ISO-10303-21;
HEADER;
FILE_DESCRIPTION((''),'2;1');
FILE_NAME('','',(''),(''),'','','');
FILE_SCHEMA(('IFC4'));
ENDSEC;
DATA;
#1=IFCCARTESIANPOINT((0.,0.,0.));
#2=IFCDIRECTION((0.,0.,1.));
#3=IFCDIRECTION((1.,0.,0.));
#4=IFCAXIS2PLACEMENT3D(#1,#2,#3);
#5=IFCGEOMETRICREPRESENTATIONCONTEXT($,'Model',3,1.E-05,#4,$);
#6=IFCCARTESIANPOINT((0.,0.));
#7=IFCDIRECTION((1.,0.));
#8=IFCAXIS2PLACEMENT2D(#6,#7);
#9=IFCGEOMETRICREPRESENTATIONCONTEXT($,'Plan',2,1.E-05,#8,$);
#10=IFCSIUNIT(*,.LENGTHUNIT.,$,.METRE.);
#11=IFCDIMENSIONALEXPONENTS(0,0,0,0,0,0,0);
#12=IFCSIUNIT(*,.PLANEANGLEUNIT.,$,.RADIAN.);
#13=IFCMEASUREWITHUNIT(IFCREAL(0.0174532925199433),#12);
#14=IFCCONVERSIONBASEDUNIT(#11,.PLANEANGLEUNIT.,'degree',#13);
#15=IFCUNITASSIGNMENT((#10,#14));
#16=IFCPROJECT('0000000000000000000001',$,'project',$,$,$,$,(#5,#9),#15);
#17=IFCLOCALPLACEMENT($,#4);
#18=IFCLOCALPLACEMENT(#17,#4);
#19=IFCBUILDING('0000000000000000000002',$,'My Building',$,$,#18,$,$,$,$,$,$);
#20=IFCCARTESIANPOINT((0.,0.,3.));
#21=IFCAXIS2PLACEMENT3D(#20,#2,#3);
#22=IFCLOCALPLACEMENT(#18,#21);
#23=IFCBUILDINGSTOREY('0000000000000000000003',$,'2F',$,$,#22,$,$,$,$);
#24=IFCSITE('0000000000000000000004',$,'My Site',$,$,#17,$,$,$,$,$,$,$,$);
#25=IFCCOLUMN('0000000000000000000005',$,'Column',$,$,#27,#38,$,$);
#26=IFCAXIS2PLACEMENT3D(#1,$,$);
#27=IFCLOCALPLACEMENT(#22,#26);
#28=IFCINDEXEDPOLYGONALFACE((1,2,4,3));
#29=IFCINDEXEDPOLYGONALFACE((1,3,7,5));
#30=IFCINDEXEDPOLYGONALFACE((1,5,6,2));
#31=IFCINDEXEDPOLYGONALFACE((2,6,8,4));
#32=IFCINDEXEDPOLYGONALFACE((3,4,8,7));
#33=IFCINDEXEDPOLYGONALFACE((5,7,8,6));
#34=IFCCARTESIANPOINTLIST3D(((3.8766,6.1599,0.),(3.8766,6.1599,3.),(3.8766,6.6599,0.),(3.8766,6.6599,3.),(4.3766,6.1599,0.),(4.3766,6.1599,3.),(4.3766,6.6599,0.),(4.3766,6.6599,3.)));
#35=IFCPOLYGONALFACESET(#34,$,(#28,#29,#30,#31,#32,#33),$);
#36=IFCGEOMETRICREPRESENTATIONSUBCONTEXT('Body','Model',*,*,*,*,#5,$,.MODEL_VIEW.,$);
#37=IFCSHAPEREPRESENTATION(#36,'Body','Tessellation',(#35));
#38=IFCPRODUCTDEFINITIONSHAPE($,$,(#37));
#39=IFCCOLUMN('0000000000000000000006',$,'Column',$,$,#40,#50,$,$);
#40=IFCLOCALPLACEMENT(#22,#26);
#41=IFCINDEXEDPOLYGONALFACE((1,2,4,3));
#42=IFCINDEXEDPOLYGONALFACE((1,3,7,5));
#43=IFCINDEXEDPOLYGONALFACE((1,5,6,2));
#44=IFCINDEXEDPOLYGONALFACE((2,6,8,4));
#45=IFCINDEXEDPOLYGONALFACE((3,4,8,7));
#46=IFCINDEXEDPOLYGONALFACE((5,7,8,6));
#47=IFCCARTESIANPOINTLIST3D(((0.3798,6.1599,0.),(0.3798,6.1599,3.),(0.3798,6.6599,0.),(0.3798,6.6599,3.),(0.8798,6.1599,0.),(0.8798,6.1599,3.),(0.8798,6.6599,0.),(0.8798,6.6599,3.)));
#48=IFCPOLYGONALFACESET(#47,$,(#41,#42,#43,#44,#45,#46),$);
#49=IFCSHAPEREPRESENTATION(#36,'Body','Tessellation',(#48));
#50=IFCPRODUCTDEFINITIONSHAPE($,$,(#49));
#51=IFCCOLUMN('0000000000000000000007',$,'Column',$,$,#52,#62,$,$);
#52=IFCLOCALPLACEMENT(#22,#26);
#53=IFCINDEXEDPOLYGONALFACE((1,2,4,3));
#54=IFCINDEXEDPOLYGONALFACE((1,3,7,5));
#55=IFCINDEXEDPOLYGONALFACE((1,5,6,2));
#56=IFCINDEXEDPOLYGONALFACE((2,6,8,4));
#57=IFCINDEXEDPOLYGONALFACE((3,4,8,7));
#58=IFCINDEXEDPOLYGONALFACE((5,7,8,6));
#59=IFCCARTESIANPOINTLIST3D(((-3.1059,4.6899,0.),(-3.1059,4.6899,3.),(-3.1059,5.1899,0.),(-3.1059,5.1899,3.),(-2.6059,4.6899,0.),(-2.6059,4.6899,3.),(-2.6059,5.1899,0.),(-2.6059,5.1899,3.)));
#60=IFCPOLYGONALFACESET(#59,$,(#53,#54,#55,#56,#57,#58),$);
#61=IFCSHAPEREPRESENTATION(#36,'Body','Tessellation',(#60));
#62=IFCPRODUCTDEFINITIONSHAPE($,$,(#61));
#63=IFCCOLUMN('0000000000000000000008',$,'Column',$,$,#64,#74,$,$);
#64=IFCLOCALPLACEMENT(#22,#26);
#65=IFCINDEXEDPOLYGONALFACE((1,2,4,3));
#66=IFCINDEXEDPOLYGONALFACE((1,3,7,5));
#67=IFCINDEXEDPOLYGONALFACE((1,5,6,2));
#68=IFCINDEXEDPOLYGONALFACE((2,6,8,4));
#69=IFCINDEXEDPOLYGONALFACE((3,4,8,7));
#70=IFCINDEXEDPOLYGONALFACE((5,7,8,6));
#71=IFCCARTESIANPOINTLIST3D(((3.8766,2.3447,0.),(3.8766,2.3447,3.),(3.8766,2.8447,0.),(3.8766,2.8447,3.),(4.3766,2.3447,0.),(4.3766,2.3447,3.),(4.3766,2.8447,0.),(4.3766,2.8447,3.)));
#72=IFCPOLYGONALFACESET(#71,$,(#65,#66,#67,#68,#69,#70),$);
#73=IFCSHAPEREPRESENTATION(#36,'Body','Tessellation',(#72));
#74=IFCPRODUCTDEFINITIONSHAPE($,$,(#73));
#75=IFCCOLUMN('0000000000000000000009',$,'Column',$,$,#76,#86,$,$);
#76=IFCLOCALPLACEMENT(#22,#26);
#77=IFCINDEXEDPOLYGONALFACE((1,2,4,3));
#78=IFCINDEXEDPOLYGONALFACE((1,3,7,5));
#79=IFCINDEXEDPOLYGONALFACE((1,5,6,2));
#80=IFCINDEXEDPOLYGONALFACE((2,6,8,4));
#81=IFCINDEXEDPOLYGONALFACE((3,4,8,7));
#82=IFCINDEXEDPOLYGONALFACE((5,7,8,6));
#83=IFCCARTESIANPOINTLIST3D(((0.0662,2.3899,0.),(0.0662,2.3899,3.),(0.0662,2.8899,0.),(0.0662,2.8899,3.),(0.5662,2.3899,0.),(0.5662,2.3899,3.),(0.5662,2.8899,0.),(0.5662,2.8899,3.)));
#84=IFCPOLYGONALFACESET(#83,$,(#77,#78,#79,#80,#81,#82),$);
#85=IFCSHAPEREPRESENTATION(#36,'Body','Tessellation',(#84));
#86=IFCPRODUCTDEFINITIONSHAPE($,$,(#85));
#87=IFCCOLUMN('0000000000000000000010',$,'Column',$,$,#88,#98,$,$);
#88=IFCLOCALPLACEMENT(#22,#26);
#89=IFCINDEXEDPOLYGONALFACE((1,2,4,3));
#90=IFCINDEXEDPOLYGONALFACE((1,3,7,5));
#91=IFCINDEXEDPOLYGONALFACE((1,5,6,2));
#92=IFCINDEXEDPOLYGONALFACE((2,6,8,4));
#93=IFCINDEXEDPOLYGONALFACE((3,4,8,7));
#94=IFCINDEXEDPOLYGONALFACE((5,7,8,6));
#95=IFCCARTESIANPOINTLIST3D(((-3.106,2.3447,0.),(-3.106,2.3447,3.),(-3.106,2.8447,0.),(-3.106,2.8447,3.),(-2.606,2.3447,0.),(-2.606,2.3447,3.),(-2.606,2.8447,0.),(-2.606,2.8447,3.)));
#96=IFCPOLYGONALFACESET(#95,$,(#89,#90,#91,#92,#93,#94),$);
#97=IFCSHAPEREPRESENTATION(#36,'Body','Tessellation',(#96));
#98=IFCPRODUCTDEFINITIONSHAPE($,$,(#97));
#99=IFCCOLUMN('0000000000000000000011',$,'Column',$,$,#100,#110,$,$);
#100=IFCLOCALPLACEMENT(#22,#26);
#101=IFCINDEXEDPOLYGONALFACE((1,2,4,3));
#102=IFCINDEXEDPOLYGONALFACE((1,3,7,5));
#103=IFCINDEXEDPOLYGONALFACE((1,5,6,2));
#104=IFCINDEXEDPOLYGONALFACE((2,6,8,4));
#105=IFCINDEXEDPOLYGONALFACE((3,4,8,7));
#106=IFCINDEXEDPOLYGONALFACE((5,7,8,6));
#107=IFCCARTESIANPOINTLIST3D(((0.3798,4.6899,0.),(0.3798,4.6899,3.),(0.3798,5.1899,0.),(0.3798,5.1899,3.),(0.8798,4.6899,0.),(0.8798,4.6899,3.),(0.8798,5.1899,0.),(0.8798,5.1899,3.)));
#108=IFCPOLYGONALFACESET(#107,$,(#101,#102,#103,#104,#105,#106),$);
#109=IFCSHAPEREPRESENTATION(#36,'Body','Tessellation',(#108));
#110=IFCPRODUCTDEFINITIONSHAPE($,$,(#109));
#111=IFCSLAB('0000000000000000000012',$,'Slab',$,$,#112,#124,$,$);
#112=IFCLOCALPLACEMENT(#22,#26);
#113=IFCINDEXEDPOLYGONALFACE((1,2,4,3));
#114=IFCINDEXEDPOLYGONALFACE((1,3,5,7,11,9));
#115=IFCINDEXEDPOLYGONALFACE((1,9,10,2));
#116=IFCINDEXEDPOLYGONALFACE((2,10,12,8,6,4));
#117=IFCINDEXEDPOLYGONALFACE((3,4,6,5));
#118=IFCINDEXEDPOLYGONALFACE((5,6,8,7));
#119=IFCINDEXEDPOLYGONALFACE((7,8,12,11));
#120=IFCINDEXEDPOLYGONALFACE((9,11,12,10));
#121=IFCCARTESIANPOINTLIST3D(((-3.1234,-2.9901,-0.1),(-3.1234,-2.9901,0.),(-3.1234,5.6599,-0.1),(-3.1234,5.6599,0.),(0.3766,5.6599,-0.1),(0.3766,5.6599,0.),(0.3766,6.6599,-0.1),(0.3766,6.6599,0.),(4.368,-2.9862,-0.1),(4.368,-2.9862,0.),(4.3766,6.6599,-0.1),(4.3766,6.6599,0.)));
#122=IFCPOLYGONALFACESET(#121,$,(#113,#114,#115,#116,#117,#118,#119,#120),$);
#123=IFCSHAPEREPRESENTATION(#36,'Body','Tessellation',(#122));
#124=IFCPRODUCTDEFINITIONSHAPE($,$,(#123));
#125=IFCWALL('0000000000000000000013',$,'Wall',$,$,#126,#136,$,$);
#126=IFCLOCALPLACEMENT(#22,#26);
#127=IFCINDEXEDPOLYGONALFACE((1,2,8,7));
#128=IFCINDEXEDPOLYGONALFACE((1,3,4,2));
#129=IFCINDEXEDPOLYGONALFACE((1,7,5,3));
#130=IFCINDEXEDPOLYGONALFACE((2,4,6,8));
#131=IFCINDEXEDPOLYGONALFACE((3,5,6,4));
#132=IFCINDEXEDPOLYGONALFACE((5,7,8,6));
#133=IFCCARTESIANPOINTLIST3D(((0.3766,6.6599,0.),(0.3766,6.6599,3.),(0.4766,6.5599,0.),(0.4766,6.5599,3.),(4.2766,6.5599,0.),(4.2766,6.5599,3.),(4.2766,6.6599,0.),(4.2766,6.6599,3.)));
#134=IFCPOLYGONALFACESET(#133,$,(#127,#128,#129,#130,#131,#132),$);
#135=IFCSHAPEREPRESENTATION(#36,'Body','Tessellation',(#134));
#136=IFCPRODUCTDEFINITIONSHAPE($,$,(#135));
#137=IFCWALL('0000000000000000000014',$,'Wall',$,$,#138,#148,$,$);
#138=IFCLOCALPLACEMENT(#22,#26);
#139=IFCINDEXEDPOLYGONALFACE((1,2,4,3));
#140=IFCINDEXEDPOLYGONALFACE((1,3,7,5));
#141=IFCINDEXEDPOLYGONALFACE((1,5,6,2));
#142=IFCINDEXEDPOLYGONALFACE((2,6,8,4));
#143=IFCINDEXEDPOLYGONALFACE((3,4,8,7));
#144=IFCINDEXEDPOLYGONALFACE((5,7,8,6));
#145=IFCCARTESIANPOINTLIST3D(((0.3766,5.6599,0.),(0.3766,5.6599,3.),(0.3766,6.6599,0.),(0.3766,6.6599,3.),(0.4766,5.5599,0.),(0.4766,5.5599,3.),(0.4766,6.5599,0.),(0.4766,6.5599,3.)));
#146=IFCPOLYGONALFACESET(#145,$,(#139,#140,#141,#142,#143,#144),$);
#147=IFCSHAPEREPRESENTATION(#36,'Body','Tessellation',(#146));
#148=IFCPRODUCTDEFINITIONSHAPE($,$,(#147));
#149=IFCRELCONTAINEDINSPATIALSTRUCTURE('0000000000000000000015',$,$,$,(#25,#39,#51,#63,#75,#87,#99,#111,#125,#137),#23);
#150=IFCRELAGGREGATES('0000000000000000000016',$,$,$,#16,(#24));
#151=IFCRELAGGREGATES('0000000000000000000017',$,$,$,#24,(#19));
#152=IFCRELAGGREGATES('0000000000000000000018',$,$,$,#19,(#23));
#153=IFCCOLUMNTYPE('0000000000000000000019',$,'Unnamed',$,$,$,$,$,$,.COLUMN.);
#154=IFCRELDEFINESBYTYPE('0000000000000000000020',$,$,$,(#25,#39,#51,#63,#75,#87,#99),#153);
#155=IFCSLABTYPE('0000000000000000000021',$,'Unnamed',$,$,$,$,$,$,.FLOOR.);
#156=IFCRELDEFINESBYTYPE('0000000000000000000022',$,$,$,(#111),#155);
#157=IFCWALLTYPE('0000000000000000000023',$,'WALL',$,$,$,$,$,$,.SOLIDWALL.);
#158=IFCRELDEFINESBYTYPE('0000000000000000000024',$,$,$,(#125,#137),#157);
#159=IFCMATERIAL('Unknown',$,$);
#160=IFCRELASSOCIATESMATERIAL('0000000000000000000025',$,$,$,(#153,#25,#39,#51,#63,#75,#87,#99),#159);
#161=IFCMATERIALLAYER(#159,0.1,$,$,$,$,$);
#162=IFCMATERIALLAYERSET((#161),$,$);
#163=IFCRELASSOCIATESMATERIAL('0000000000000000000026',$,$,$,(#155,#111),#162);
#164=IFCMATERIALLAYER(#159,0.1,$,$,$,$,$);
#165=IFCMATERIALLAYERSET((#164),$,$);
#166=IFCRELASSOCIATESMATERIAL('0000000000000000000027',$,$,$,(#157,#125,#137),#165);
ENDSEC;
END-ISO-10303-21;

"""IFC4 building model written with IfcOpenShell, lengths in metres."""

from ifc_helpers import new_model, entity, si_unit, converted_unit, frame, origin_with_axes, origin_2d_with_axis, place, context, subcontext, project, spatial, line, indexed_curve, rectangle, outline, extrude, material, layer, layer_set, layer_usage, material_profile, profile_set, profile_usage, type_object, element, save


model = new_model("IFC4")

# Units and contexts
model_context = context("Model", 3, precision=1e-05, world=origin_with_axes())
plan_context = context("Plan", 2, precision=1e-05, world=origin_2d_with_axis())
body_context_1 = subcontext(model_context, "Body", "Model", "MODEL_VIEW")
ifc_project = project(units=[si_unit("LENGTHUNIT", "METRE"), converted_unit("PLANEANGLEUNIT", "degree", entity("IfcReal", 0.0174532925199433), si_unit("PLANEANGLEUNIT", "RADIAN"), dimensions=[0, 0, 0, 0, 0, 0, 0])], contexts=[model_context, plan_context])

# Site, building, storey
site_placement = place(None, origin_with_axes())
site = spatial("IfcSite", under=ifc_project, at=site_placement, Name="My Site")
building_placement = place(site_placement, origin_with_axes())
building = spatial("IfcBuilding", under=site, at=building_placement, Name="My Building")
storey_placement = place(building_placement, frame((0.0, 0.0, 3.0), z_axis=(0.0, 0.0, 1.0), x_axis=(1.0, 0.0, 0.0)))
storey = spatial("IfcBuildingStorey", under=building, at=storey_placement, Name="2F")

# Columns
ifc_material = material(Name="Unknown")
ifc_material_profile = material_profile(ifc_material, rectangle(XDim=0.5, YDim=0.5))
ifc_profile_set = profile_set([ifc_material_profile])
ifc_profile_usage_1 = profile_usage(ifc_profile_set, cardinal=7)
column_type = type_object("IfcColumnType", Name="Unnamed", PredefinedType="COLUMN", material=ifc_profile_set)
column_1_placement = place(storey_placement, frame((4.3766, 6.6599, 0.0), z_axis=(0.0, 0.0, 1.0), x_axis=(1.0, 0.0, 0.0)))
element("IfcColumn", 1, at=column_1_placement, inside=storey, type_object=column_type, material=ifc_profile_usage_1, Name="Column", context=body_context_1, shape_type="SweptSolid", body=[
    extrude(rectangle(XDim=0.5, YDim=0.5), frame((-0.25, -0.25, 0.0), z_axis=(0.0, 0.0, 1.0), x_axis=(1.0, 0.0, 0.0)), (0.0, 0.0, 1.0), 3.0),
])
ifc_profile_usage_2 = profile_usage(ifc_profile_set, cardinal=7)
column_2_placement = place(storey_placement, frame((0.8798, 6.6599, 0.0), z_axis=(0.0, 0.0, 1.0), x_axis=(1.0, 0.0, 0.0)))
element("IfcColumn", 2, at=column_2_placement, inside=storey, type_object=column_type, material=ifc_profile_usage_2, Name="Column", context=body_context_1, shape_type="SweptSolid", body=[
    extrude(rectangle(XDim=0.5, YDim=0.5), frame((-0.25, -0.25, 0.0), z_axis=(0.0, 0.0, 1.0), x_axis=(1.0, 0.0, 0.0)), (0.0, 0.0, 1.0), 3.0),
])
ifc_profile_usage_3 = profile_usage(ifc_profile_set, cardinal=7)
column_3_placement = place(storey_placement, frame((-2.6059, 5.1899, 0.0), z_axis=(0.0, 0.0, 1.0), x_axis=(1.0, 0.0, 0.0)))
element("IfcColumn", 3, at=column_3_placement, inside=storey, type_object=column_type, material=ifc_profile_usage_3, Name="Column", context=body_context_1, shape_type="SweptSolid", body=[
    extrude(rectangle(XDim=0.5, YDim=0.5), frame((-0.25, -0.25, 0.0), z_axis=(0.0, 0.0, 1.0), x_axis=(1.0, 0.0, 0.0)), (0.0, 0.0, 1.0), 3.0),
])
ifc_profile_usage_4 = profile_usage(ifc_profile_set, cardinal=7)
column_4_placement = place(storey_placement, frame((4.3766, 2.8447, 0.0), z_axis=(0.0, 0.0, 1.0), x_axis=(1.0, 0.0, 0.0)))
element("IfcColumn", 4, at=column_4_placement, inside=storey, type_object=column_type, material=ifc_profile_usage_4, Name="Column", context=body_context_1, shape_type="SweptSolid", body=[
    extrude(rectangle(XDim=0.5, YDim=0.5), frame((-0.25, -0.25, 0.0), z_axis=(0.0, 0.0, 1.0), x_axis=(1.0, 0.0, 0.0)), (0.0, 0.0, 1.0), 3.0),
])
ifc_profile_usage_5 = profile_usage(ifc_profile_set, cardinal=7)
column_5_placement = place(storey_placement, frame((0.5662, 2.8899, 0.0), z_axis=(0.0, 0.0, 1.0), x_axis=(1.0, 0.0, 0.0)))
element("IfcColumn", 5, at=column_5_placement, inside=storey, type_object=column_type, material=ifc_profile_usage_5, Name="Column", context=body_context_1, shape_type="SweptSolid", body=[
    extrude(rectangle(XDim=0.5, YDim=0.5), frame((-0.25, -0.25, 0.0), z_axis=(0.0, 0.0, 1.0), x_axis=(1.0, 0.0, 0.0)), (0.0, 0.0, 1.0), 3.0),
])
ifc_profile_usage_6 = profile_usage(ifc_profile_set, cardinal=7)
column_6_placement = place(storey_placement, frame((-2.606, 2.8447, 0.0), z_axis=(0.0, 0.0, 1.0), x_axis=(1.0, 0.0, 0.0)))
element("IfcColumn", 6, at=column_6_placement, inside=storey, type_object=column_type, material=ifc_profile_usage_6, Name="Column", context=body_context_1, shape_type="SweptSolid", body=[
    extrude(rectangle(XDim=0.5, YDim=0.5), frame((-0.25, -0.25, 0.0), z_axis=(0.0, 0.0, 1.0), x_axis=(1.0, 0.0, 0.0)), (0.0, 0.0, 1.0), 3.0),
])
ifc_profile_usage_7 = profile_usage(ifc_profile_set, cardinal=1)
column_7_placement = place(storey_placement, frame((0.8798, 4.6899, 0.0), z_axis=(0.0, 0.0, 1.0), x_axis=(1.0, 0.0, 0.0)))
element("IfcColumn", 7, at=column_7_placement, inside=storey, type_object=column_type, material=ifc_profile_usage_7, Name="Column", context=body_context_1, shape_type="SweptSolid", body=[
    extrude(rectangle(XDim=0.5, YDim=0.5), frame((-0.25, 0.25, 0.0), z_axis=(0.0, 0.0, 1.0), x_axis=(1.0, 0.0, 0.0)), (0.0, 0.0, 1.0), 3.0),
])

# Slab
ifc_layer_1 = layer(ifc_material, 0.1)
ifc_layer_set_1 = layer_set([ifc_layer_1])
ifc_layer_usage_1 = layer_usage(ifc_layer_set_1, "AXIS3", "POSITIVE", -0.1)
slab_type = type_object("IfcSlabType", Name="Unnamed", PredefinedType="FLOOR", material=ifc_layer_set_1)
slab_placement = place(storey_placement, frame((4.3766, 6.6599, 0.0), z_axis=(0.0, 0.0, 1.0), x_axis=(1.0, 0.0, 0.0)))
element("IfcSlab", 8, at=slab_placement, inside=storey, type_object=slab_type, material=ifc_layer_usage_1, Name="Slab", context=body_context_1, shape_type="SweptSolid", body=[
    extrude(outline(indexed_curve([(0.0, 0.0), (-4.0, 0.0), (-4.0, -1.0), (-7.5, -1.0), (-7.5, -9.65), (-0.0086, -9.6461), (0.0, 0.0)])), frame((0.0, 0.0, -0.1), z_axis=(0.0, 0.0, 1.0), x_axis=(1.0, 0.0, 0.0)), (0.0, 0.0, 1.0), 0.1),
])

# Walls
ifc_layer_2 = layer(ifc_material, 0.1)
ifc_layer_set_2 = layer_set([ifc_layer_2])
ifc_layer_usage_2 = layer_usage(ifc_layer_set_2, "AXIS2", "POSITIVE", 0.0)
wall_type = type_object("IfcWallType", Name="WALL", PredefinedType="SOLIDWALL", material=ifc_layer_set_2)
wall_1_placement = place(storey_placement, frame((4.2766, 6.6599, 0.0), z_axis=(0.0, 0.0, 1.0), x_axis=(-1.0, 0.0, 0.0)))
element("IfcWall", 9, at=wall_1_placement, inside=storey, type_object=wall_type, material=ifc_layer_usage_2, Name="Wall", context=body_context_1, shape_type="SweptSolid", body=[
    extrude(outline(indexed_curve([(0.0, 0.0), (0.0, 0.1), (3.8, 0.1), (3.9, 0.0)], segments=[line(1, 2, 3, 4, 1)])), origin_with_axes(), (0.0, 0.0, 1.0), 3.0),
])
ifc_layer_usage_3 = layer_usage(ifc_layer_set_2, "AXIS2", "POSITIVE", 0.0)
wall_2_placement = place(storey_placement, frame((0.3766, 6.6599, 0.0), z_axis=(0.0, 0.0, 1.0), x_axis=(0.0, -1.0, 0.0)))
element("IfcWall", 10, at=wall_2_placement, inside=storey, type_object=wall_type, material=ifc_layer_usage_3, Name="Wall", context=body_context_1, shape_type="SweptSolid", body=[
    extrude(outline(indexed_curve([(0.0, 0.0), (0.1, 0.1), (1.1, 0.1), (1.0, 0.0)], segments=[line(1, 2, 3, 4, 1)])), origin_with_axes(), (0.0, 0.0, 1.0), 3.0),
])

save(model, "model.ifc")
